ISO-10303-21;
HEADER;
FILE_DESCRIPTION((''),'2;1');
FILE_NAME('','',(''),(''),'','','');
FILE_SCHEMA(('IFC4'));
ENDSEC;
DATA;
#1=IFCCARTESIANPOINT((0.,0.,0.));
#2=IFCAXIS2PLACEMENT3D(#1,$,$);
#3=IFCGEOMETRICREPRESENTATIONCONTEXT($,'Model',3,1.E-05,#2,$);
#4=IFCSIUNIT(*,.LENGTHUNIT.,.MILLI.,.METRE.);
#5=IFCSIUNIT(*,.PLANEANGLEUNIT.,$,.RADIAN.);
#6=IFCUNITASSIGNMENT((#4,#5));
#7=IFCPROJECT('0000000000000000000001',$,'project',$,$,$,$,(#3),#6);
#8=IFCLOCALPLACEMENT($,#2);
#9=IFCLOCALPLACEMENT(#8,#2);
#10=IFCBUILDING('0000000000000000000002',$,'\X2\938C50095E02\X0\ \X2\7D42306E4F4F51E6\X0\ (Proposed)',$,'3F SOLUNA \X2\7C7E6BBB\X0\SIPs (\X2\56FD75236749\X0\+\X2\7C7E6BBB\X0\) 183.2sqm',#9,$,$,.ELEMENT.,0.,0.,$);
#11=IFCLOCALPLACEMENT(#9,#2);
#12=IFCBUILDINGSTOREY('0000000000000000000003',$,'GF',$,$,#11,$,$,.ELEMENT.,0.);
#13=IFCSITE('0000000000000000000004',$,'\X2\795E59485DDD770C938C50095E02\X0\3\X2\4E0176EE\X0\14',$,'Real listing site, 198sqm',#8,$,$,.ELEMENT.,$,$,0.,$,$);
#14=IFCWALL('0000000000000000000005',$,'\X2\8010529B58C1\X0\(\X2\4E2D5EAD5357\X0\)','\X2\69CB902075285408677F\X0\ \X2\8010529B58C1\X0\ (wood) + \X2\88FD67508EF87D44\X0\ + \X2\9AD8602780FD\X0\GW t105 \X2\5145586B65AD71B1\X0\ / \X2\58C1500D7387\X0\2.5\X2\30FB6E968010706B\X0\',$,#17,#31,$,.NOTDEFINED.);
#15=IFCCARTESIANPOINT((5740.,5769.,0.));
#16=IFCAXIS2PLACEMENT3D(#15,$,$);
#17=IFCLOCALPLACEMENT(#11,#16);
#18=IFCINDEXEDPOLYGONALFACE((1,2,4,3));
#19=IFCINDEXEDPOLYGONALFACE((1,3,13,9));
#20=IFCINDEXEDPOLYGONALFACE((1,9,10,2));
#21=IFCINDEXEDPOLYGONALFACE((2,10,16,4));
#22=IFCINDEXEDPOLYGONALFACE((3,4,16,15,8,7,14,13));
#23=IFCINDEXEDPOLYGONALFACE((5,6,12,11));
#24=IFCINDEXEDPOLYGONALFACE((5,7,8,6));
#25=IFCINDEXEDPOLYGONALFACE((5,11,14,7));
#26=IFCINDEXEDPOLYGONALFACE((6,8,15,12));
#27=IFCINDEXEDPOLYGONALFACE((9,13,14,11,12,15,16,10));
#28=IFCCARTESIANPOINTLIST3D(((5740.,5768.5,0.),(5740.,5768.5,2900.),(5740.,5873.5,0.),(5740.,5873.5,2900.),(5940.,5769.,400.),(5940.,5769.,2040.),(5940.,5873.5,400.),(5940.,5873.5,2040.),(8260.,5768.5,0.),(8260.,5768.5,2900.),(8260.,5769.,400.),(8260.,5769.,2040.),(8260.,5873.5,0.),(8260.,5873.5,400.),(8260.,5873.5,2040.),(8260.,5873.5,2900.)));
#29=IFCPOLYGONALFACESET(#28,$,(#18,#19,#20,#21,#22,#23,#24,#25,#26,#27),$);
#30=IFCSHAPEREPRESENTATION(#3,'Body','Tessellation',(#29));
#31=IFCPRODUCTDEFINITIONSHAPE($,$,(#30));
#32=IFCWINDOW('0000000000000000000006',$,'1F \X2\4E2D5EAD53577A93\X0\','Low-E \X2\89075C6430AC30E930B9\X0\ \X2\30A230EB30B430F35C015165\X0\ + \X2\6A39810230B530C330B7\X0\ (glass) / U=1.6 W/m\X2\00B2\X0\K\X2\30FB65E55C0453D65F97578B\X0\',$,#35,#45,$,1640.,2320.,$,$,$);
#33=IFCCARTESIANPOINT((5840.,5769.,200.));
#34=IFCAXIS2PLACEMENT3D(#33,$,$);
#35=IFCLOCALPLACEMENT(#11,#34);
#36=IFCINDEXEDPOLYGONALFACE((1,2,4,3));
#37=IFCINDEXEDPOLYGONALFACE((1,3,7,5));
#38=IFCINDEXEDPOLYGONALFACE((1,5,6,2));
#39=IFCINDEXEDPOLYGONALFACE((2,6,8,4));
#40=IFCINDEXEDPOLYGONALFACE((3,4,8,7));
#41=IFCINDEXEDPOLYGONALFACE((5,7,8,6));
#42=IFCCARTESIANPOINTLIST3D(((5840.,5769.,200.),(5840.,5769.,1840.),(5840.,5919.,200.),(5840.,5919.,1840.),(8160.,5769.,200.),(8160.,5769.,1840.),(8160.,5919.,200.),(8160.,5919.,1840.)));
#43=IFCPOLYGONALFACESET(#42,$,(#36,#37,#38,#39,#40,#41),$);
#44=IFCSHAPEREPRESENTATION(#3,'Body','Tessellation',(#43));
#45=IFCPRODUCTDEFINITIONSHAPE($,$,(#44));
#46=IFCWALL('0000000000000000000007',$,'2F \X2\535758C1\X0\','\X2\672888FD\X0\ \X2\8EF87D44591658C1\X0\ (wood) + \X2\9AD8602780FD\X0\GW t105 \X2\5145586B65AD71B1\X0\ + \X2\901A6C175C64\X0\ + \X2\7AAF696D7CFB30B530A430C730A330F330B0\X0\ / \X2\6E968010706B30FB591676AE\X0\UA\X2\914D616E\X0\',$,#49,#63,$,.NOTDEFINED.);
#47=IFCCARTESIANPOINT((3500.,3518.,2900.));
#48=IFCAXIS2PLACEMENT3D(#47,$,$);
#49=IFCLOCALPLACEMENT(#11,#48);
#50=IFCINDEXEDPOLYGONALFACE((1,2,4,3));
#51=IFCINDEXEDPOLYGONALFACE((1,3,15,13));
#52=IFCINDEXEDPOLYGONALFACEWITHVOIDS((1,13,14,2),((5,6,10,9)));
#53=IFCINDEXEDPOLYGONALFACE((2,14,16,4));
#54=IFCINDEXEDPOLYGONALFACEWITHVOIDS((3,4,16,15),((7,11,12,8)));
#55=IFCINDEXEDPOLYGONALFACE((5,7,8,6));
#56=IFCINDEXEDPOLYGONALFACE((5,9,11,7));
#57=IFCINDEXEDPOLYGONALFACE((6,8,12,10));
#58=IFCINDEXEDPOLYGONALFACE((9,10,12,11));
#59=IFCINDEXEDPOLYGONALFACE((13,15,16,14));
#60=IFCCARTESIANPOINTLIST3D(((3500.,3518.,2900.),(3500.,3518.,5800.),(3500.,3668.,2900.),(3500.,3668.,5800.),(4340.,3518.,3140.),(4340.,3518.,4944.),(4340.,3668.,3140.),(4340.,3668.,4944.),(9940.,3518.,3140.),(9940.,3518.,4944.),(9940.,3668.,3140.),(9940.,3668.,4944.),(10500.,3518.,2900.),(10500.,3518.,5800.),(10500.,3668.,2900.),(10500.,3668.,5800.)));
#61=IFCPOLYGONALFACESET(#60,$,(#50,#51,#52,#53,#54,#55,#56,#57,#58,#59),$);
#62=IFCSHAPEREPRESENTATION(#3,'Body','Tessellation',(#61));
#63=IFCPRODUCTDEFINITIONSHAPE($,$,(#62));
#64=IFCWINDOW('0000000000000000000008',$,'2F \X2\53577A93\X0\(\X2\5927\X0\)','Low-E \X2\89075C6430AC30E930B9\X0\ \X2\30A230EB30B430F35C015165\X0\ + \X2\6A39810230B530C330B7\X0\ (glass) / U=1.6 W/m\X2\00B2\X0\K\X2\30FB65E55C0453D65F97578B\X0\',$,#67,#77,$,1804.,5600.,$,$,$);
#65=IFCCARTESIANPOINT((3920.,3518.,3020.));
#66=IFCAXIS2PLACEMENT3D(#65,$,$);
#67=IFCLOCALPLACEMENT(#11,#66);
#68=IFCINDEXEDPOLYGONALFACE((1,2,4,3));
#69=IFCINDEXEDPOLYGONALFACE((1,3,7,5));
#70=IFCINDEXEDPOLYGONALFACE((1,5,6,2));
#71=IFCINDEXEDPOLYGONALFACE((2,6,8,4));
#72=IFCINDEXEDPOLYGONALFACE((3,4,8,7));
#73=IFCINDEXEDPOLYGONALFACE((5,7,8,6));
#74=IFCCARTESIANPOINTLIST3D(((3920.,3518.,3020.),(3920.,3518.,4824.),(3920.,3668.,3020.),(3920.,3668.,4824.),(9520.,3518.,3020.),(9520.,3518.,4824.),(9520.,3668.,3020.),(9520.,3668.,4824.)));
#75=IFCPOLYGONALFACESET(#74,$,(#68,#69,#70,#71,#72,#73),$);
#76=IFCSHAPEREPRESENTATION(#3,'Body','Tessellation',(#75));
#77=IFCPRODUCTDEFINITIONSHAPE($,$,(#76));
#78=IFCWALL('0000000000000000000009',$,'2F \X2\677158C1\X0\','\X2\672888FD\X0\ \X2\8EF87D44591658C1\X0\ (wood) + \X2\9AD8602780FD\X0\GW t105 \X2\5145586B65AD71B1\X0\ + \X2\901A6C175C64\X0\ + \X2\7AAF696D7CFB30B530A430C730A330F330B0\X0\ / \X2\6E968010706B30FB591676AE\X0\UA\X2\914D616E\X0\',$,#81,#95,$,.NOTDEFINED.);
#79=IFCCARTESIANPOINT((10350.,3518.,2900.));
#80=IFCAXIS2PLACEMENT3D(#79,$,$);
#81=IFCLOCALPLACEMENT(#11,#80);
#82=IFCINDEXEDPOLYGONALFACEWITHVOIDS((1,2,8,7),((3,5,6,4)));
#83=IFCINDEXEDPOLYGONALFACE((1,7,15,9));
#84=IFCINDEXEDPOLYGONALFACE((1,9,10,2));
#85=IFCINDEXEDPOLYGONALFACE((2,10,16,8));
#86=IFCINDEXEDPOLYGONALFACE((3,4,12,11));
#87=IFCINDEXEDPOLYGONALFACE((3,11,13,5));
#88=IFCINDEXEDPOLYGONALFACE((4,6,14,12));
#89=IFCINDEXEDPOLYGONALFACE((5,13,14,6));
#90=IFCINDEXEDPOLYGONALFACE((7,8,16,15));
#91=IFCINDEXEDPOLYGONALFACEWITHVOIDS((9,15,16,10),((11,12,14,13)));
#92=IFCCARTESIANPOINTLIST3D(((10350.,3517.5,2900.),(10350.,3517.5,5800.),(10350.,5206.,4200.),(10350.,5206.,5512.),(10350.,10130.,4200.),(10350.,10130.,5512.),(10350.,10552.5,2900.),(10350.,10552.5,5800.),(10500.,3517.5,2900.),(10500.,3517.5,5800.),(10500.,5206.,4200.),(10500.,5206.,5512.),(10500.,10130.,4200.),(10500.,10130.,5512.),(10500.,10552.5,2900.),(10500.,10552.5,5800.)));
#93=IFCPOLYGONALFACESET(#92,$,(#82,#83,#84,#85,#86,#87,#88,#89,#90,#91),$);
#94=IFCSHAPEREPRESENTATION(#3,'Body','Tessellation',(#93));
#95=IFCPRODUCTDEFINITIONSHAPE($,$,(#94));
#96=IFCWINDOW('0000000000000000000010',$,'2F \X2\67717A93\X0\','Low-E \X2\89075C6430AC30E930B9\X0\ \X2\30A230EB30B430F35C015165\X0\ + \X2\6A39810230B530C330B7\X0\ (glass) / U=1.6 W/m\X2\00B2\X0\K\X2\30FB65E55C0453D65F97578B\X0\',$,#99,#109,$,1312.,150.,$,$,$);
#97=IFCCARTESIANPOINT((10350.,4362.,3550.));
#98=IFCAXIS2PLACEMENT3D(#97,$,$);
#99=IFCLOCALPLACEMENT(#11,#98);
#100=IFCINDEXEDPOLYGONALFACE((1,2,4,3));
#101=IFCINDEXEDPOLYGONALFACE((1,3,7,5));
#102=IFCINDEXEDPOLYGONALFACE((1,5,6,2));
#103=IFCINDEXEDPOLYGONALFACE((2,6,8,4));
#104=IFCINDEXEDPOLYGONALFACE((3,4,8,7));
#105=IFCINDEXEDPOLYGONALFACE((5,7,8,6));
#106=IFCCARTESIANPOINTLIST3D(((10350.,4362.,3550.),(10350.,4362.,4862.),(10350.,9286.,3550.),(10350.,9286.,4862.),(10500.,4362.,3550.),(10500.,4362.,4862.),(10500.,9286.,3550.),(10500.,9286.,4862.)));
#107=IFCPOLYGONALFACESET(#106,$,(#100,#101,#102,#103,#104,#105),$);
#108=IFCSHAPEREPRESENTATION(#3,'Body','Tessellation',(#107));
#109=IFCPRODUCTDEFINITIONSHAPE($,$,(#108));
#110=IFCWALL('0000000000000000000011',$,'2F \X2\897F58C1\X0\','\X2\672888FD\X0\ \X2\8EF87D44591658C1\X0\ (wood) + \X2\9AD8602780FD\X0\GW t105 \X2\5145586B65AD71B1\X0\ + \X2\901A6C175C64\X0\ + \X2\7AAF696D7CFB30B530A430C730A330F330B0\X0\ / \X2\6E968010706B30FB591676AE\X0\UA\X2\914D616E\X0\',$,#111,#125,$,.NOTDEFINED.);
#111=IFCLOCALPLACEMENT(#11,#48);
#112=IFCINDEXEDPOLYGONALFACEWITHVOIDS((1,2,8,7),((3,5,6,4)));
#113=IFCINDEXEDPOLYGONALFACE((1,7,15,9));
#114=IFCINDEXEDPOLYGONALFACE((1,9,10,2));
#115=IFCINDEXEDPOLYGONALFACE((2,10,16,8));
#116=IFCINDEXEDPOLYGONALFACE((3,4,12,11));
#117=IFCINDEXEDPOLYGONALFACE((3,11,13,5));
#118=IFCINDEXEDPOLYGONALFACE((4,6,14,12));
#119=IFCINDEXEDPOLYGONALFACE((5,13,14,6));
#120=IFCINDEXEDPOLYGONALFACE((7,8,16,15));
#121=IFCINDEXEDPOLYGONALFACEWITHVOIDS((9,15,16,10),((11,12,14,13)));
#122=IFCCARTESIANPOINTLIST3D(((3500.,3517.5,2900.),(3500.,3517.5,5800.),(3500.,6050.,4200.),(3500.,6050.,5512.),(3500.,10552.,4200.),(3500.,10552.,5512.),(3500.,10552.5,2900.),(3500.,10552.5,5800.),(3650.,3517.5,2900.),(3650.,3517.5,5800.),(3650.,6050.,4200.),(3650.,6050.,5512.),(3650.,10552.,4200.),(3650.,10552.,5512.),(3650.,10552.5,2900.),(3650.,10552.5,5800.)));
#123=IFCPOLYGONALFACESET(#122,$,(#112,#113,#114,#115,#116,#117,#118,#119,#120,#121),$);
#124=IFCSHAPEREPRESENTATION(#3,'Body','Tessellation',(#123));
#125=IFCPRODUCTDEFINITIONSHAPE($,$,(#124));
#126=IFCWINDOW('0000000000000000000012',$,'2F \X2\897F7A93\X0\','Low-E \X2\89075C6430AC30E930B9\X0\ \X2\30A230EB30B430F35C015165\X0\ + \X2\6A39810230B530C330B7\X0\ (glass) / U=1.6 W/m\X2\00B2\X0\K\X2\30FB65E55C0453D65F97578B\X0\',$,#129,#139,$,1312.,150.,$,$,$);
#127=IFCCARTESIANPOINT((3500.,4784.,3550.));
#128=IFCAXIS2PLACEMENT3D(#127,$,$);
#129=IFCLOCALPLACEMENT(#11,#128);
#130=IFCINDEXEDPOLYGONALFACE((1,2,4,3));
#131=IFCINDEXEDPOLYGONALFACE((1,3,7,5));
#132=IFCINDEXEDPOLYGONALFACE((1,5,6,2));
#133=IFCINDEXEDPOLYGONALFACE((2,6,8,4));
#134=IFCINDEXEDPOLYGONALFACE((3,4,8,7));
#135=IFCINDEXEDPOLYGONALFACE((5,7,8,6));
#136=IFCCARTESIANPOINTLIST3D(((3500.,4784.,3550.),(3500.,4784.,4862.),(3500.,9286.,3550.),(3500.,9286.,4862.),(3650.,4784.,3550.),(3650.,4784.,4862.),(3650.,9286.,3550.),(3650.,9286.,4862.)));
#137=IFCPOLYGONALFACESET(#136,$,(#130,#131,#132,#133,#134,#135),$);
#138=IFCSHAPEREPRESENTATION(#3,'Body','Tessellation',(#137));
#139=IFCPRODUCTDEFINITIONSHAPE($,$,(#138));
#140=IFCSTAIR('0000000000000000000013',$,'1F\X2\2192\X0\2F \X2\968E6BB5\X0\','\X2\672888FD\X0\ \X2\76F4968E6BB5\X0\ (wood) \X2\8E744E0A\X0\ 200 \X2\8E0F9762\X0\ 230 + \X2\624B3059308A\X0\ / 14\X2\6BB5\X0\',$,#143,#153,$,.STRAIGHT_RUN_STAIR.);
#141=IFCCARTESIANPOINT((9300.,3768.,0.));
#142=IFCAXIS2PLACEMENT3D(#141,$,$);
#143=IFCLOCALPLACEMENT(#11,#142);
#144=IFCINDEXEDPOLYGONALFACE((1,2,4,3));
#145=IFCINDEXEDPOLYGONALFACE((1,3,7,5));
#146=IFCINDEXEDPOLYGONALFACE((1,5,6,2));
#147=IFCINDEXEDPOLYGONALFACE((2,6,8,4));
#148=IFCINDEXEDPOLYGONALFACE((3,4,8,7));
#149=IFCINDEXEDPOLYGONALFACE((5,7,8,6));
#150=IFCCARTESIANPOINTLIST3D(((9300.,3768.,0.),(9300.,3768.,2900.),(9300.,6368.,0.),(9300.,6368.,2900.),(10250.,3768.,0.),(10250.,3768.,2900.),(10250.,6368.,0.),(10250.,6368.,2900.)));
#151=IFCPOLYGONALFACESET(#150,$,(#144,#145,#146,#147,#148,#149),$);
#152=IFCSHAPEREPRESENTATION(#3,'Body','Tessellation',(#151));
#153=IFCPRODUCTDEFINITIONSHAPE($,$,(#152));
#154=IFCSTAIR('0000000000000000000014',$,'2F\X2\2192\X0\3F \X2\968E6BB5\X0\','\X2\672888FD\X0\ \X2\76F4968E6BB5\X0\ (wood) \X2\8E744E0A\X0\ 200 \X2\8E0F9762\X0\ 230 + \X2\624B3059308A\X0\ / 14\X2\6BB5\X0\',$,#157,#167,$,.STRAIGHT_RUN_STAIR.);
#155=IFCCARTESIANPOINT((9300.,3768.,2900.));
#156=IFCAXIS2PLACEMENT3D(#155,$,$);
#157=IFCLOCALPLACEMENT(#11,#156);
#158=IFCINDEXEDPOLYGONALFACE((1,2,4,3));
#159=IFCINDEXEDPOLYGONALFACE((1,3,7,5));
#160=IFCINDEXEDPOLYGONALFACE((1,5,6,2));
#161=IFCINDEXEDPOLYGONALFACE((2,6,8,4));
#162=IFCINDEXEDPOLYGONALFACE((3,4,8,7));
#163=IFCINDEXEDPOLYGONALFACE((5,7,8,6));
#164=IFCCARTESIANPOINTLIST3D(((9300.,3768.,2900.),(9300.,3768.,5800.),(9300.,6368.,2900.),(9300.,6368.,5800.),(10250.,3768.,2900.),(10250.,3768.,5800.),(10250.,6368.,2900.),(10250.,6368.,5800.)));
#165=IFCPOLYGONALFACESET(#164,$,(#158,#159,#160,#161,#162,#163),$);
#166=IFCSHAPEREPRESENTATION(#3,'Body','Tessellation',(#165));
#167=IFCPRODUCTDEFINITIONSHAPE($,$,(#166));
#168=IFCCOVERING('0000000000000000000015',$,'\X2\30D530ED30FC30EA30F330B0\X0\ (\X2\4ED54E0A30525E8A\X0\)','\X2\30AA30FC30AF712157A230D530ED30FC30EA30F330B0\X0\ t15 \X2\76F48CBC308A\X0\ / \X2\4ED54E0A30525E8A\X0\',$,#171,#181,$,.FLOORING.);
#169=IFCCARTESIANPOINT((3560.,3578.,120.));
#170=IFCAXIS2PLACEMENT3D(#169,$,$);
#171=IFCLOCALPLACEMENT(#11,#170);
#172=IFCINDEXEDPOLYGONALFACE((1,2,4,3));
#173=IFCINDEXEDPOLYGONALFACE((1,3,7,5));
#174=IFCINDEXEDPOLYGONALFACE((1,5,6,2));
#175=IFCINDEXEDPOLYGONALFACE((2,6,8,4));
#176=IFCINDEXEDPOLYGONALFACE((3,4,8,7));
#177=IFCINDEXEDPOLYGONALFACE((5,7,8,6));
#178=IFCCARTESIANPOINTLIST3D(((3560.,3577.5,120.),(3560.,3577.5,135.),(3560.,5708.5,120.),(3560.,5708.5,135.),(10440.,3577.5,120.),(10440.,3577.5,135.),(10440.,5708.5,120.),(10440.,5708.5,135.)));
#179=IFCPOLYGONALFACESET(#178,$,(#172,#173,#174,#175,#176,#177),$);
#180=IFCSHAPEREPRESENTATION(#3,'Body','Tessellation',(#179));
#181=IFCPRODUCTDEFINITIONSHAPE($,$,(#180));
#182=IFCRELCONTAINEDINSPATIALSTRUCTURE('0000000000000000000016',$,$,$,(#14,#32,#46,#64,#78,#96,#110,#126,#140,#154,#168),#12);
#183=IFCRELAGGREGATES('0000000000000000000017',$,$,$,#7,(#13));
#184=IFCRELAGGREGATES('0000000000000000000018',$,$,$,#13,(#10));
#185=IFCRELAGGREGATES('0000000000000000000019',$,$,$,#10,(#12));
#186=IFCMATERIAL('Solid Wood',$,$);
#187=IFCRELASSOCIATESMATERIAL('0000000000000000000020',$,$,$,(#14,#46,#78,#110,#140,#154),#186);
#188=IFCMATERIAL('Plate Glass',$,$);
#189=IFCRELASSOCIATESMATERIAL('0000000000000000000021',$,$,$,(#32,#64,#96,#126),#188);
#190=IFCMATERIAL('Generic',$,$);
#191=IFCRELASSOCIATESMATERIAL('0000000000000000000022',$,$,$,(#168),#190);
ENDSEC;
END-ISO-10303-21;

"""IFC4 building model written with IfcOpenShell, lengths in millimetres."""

from ifc_helpers import new_model, si_unit, frame, frame_2d, origin, place, context, project, spatial, rectangle, extrude, material, element, fill, save


model = new_model("IFC4")

# Units and contexts
model_context = context("Model", 3, precision=1e-05, world=origin())
ifc_project = project(units=[si_unit("LENGTHUNIT", "METRE", prefix="MILLI"), si_unit("PLANEANGLEUNIT", "RADIAN")], contexts=[model_context])

# Site, building, storey
site_placement = place(None, origin())
site = spatial("IfcSite", under=ifc_project, at=site_placement, Name="神奈川県鎌倉市3丁目14", ObjectType="Real listing site, 198sqm", CompositionType="ELEMENT", RefElevation=0.0)
building_placement = place(site_placement, origin())
building = spatial("IfcBuilding", under=site, at=building_placement, Name="鎌倉市 終の住処 (Proposed)", ObjectType="3F SOLUNA 籾殻SIPs (国産杉+籾殻) 183.2sqm", CompositionType="ELEMENT", ElevationOfRefHeight=0.0, ElevationOfTerrain=0.0)
storey_placement = place(building_placement, origin())
storey = spatial("IfcBuildingStorey", under=building, at=storey_placement, Name="GF", CompositionType="ELEMENT", Elevation=0.0)

# Shared definitions
ifc_material_1 = material(Name="Solid Wood")

# Shared definitions
ifc_material_2 = material(Name="Plate Glass")

# Walls, openings, windows
wall_1_placement = place(storey_placement, frame((5740.0, 5769.0, 0.0)))
wall_1 = element("IfcWall", 1, at=wall_1_placement, inside=storey, material=ifc_material_1, Name="耐力壁(中庭南)", Description="構造用合板 耐力壁 (wood) + 製材軸組 + 高性能GW t105 充填断熱 / 壁倍率2.5・準耐火", PredefinedType="NOTDEFINED", context=model_context, shape_type="SweptSolid", body=[
    extrude(rectangle(XDim=2520.0, YDim=105.0, at=frame_2d((1260.0, 52.0))), frame((5740.0, 5769.0, 0.0)), (0.0, 0.0, 1.0), 2900.0),
])
opening_1_placement = place(storey_placement, frame((5840.0, 5769.0, 200.0)))
opening_1 = element("IfcOpeningElement", 2, at=opening_1_placement, cuts=wall_1, PredefinedType="NOTDEFINED", context=model_context, shape_type="SweptSolid", body=[
    extrude(rectangle(XDim=2320.0, YDim=150.0, at=frame_2d((1160.0, 75.0))), frame((5840.0, 5769.0, 200.0)), (0.0, 0.0, 1.0), 1640.0),
])
window_1_placement = place(storey_placement, frame((5840.0, 5769.0, 200.0)))
window_1 = element("IfcWindow", 3, at=window_1_placement, inside=storey, material=ifc_material_2, Name="1F 中庭南窓", Description="Low-E 複層ガラス アルゴン封入 + 樹脂サッシ (glass) / U=1.6 W/m²K・日射取得型", OverallHeight=1640.0, OverallWidth=2320.0, context=model_context, shape_type="SweptSolid", body=[
    extrude(rectangle(XDim=2320.0, YDim=150.0, at=frame_2d((1160.0, 75.0))), frame((5840.0, 5769.0, 200.0)), (0.0, 0.0, 1.0), 1640.0),
])
fill(opening_1, window_1)
wall_2_placement = place(storey_placement, frame((3500.0, 3518.0, 2900.0)))
wall_2 = element("IfcWall", 4, at=wall_2_placement, inside=storey, material=ifc_material_1, Name="2F 南壁", Description="木製 軸組外壁 (wood) + 高性能GW t105 充填断熱 + 通気層 + 窯業系サイディング / 準耐火・外皮UA配慮", PredefinedType="NOTDEFINED", context=model_context, shape_type="SweptSolid", body=[
    extrude(rectangle(XDim=7000.0, YDim=150.0, at=frame_2d((3500.0, 75.0))), frame((3500.0, 3518.0, 2900.0)), (0.0, 0.0, 1.0), 2900.0),
])
opening_2_placement = place(storey_placement, frame((3920.0, 3518.0, 3020.0)))
opening_2 = element("IfcOpeningElement", 5, at=opening_2_placement, cuts=wall_2, PredefinedType="NOTDEFINED", context=model_context, shape_type="SweptSolid", body=[
    extrude(rectangle(XDim=5600.0, YDim=150.0, at=frame_2d((2800.0, 75.0))), frame((3920.0, 3518.0, 3020.0)), (0.0, 0.0, 1.0), 1804.0),
])
window_2_placement = place(storey_placement, frame((3920.0, 3518.0, 3020.0)))
window_2 = element("IfcWindow", 6, at=window_2_placement, inside=storey, material=ifc_material_2, Name="2F 南窓(大)", Description="Low-E 複層ガラス アルゴン封入 + 樹脂サッシ (glass) / U=1.6 W/m²K・日射取得型", OverallHeight=1804.0, OverallWidth=5600.0, context=model_context, shape_type="SweptSolid", body=[
    extrude(rectangle(XDim=5600.0, YDim=150.0, at=frame_2d((2800.0, 75.0))), frame((3920.0, 3518.0, 3020.0)), (0.0, 0.0, 1.0), 1804.0),
])
fill(opening_2, window_2)
wall_3_placement = place(storey_placement, frame((10350.0, 3518.0, 2900.0)))
wall_3 = element("IfcWall", 7, at=wall_3_placement, inside=storey, material=ifc_material_1, Name="2F 東壁", Description="木製 軸組外壁 (wood) + 高性能GW t105 充填断熱 + 通気層 + 窯業系サイディング / 準耐火・外皮UA配慮", PredefinedType="NOTDEFINED", context=model_context, shape_type="SweptSolid", body=[
    extrude(rectangle(XDim=150.0, YDim=7035.0, at=frame_2d((75.0, 3517.0))), frame((10350.0, 3518.0, 2900.0)), (0.0, 0.0, 1.0), 2900.0),
])
opening_3_placement = place(storey_placement, frame((10350.0, 4362.0, 3550.0)))
opening_3 = element("IfcOpeningElement", 8, at=opening_3_placement, cuts=wall_3, PredefinedType="NOTDEFINED", context=model_context, shape_type="SweptSolid", body=[
    extrude(rectangle(XDim=150.0, YDim=4924.0, at=frame_2d((75.0, 2462.0))), frame((10350.0, 4362.0, 3550.0)), (0.0, 0.0, 1.0), 1312.0),
])
window_3_placement = place(storey_placement, frame((10350.0, 4362.0, 3550.0)))
window_3 = element("IfcWindow", 9, at=window_3_placement, inside=storey, material=ifc_material_2, Name="2F 東窓", Description="Low-E 複層ガラス アルゴン封入 + 樹脂サッシ (glass) / U=1.6 W/m²K・日射取得型", OverallHeight=1312.0, OverallWidth=150.0, context=model_context, shape_type="SweptSolid", body=[
    extrude(rectangle(XDim=150.0, YDim=4924.0, at=frame_2d((75.0, 2462.0))), frame((10350.0, 4362.0, 3550.0)), (0.0, 0.0, 1.0), 1312.0),
])
fill(opening_3, window_3)
wall_4_placement = place(storey_placement, frame((3500.0, 3518.0, 2900.0)))
wall_4 = element("IfcWall", 10, at=wall_4_placement, inside=storey, material=ifc_material_1, Name="2F 西壁", Description="木製 軸組外壁 (wood) + 高性能GW t105 充填断熱 + 通気層 + 窯業系サイディング / 準耐火・外皮UA配慮", PredefinedType="NOTDEFINED", context=model_context, shape_type="SweptSolid", body=[
    extrude(rectangle(XDim=150.0, YDim=7035.0, at=frame_2d((75.0, 3517.0))), frame((3500.0, 3518.0, 2900.0)), (0.0, 0.0, 1.0), 2900.0),
])
opening_4_placement = place(storey_placement, frame((3500.0, 4784.0, 3550.0)))
opening_4 = element("IfcOpeningElement", 11, at=opening_4_placement, cuts=wall_4, PredefinedType="NOTDEFINED", context=model_context, shape_type="SweptSolid", body=[
    extrude(rectangle(XDim=150.0, YDim=4502.0, at=frame_2d((75.0, 2251.0))), frame((3500.0, 4784.0, 3550.0)), (0.0, 0.0, 1.0), 1312.0),
])
window_4_placement = place(storey_placement, frame((3500.0, 4784.0, 3550.0)))
window_4 = element("IfcWindow", 12, at=window_4_placement, inside=storey, material=ifc_material_2, Name="2F 西窓", Description="Low-E 複層ガラス アルゴン封入 + 樹脂サッシ (glass) / U=1.6 W/m²K・日射取得型", OverallHeight=1312.0, OverallWidth=150.0, context=model_context, shape_type="SweptSolid", body=[
    extrude(rectangle(XDim=150.0, YDim=4502.0, at=frame_2d((75.0, 2251.0))), frame((3500.0, 4784.0, 3550.0)), (0.0, 0.0, 1.0), 1312.0),
])
fill(opening_4, window_4)

# Stairs
stair_1_placement = place(storey_placement, frame((9300.0, 3768.0, 0.0)))
element("IfcStair", 13, at=stair_1_placement, inside=storey, material=ifc_material_1, Name="1F→2F 階段", Description="木製 直階段 (wood) 蹴上 200 踏面 230 + 手すり / 14段", PredefinedType="STRAIGHT_RUN_STAIR", context=model_context, shape_type="SweptSolid", body=[
    extrude(rectangle(XDim=950.0, YDim=2600.0, at=frame_2d((475.0, 1300.0))), frame((9300.0, 3768.0, 0.0)), (0.0, 0.0, 1.0), 2900.0),
])
stair_2_placement = place(storey_placement, frame((9300.0, 3768.0, 2900.0)))
element("IfcStair", 14, at=stair_2_placement, inside=storey, material=ifc_material_1, Name="2F→3F 階段", Description="木製 直階段 (wood) 蹴上 200 踏面 230 + 手すり / 14段", PredefinedType="STRAIGHT_RUN_STAIR", context=model_context, shape_type="SweptSolid", body=[
    extrude(rectangle(XDim=950.0, YDim=2600.0, at=frame_2d((475.0, 1300.0))), frame((9300.0, 3768.0, 2900.0)), (0.0, 0.0, 1.0), 2900.0),
])

# Covering
ifc_material_3 = material(Name="Generic")
covering_placement = place(storey_placement, frame((3560.0, 3578.0, 120.0)))
element("IfcCovering", 15, at=covering_placement, inside=storey, material=ifc_material_3, Name="フローリング (仕上げ床)", Description="オーク無垢フローリング t15 直貼り / 仕上げ床", PredefinedType="FLOORING", context=model_context, shape_type="SweptSolid", body=[
    extrude(rectangle(XDim=6880.0, YDim=2131.0, at=frame_2d((3440.0, 1065.0))), frame((3560.0, 3578.0, 120.0)), (0.0, 0.0, 1.0), 15.0),
])

save(model, "model.ifc")
